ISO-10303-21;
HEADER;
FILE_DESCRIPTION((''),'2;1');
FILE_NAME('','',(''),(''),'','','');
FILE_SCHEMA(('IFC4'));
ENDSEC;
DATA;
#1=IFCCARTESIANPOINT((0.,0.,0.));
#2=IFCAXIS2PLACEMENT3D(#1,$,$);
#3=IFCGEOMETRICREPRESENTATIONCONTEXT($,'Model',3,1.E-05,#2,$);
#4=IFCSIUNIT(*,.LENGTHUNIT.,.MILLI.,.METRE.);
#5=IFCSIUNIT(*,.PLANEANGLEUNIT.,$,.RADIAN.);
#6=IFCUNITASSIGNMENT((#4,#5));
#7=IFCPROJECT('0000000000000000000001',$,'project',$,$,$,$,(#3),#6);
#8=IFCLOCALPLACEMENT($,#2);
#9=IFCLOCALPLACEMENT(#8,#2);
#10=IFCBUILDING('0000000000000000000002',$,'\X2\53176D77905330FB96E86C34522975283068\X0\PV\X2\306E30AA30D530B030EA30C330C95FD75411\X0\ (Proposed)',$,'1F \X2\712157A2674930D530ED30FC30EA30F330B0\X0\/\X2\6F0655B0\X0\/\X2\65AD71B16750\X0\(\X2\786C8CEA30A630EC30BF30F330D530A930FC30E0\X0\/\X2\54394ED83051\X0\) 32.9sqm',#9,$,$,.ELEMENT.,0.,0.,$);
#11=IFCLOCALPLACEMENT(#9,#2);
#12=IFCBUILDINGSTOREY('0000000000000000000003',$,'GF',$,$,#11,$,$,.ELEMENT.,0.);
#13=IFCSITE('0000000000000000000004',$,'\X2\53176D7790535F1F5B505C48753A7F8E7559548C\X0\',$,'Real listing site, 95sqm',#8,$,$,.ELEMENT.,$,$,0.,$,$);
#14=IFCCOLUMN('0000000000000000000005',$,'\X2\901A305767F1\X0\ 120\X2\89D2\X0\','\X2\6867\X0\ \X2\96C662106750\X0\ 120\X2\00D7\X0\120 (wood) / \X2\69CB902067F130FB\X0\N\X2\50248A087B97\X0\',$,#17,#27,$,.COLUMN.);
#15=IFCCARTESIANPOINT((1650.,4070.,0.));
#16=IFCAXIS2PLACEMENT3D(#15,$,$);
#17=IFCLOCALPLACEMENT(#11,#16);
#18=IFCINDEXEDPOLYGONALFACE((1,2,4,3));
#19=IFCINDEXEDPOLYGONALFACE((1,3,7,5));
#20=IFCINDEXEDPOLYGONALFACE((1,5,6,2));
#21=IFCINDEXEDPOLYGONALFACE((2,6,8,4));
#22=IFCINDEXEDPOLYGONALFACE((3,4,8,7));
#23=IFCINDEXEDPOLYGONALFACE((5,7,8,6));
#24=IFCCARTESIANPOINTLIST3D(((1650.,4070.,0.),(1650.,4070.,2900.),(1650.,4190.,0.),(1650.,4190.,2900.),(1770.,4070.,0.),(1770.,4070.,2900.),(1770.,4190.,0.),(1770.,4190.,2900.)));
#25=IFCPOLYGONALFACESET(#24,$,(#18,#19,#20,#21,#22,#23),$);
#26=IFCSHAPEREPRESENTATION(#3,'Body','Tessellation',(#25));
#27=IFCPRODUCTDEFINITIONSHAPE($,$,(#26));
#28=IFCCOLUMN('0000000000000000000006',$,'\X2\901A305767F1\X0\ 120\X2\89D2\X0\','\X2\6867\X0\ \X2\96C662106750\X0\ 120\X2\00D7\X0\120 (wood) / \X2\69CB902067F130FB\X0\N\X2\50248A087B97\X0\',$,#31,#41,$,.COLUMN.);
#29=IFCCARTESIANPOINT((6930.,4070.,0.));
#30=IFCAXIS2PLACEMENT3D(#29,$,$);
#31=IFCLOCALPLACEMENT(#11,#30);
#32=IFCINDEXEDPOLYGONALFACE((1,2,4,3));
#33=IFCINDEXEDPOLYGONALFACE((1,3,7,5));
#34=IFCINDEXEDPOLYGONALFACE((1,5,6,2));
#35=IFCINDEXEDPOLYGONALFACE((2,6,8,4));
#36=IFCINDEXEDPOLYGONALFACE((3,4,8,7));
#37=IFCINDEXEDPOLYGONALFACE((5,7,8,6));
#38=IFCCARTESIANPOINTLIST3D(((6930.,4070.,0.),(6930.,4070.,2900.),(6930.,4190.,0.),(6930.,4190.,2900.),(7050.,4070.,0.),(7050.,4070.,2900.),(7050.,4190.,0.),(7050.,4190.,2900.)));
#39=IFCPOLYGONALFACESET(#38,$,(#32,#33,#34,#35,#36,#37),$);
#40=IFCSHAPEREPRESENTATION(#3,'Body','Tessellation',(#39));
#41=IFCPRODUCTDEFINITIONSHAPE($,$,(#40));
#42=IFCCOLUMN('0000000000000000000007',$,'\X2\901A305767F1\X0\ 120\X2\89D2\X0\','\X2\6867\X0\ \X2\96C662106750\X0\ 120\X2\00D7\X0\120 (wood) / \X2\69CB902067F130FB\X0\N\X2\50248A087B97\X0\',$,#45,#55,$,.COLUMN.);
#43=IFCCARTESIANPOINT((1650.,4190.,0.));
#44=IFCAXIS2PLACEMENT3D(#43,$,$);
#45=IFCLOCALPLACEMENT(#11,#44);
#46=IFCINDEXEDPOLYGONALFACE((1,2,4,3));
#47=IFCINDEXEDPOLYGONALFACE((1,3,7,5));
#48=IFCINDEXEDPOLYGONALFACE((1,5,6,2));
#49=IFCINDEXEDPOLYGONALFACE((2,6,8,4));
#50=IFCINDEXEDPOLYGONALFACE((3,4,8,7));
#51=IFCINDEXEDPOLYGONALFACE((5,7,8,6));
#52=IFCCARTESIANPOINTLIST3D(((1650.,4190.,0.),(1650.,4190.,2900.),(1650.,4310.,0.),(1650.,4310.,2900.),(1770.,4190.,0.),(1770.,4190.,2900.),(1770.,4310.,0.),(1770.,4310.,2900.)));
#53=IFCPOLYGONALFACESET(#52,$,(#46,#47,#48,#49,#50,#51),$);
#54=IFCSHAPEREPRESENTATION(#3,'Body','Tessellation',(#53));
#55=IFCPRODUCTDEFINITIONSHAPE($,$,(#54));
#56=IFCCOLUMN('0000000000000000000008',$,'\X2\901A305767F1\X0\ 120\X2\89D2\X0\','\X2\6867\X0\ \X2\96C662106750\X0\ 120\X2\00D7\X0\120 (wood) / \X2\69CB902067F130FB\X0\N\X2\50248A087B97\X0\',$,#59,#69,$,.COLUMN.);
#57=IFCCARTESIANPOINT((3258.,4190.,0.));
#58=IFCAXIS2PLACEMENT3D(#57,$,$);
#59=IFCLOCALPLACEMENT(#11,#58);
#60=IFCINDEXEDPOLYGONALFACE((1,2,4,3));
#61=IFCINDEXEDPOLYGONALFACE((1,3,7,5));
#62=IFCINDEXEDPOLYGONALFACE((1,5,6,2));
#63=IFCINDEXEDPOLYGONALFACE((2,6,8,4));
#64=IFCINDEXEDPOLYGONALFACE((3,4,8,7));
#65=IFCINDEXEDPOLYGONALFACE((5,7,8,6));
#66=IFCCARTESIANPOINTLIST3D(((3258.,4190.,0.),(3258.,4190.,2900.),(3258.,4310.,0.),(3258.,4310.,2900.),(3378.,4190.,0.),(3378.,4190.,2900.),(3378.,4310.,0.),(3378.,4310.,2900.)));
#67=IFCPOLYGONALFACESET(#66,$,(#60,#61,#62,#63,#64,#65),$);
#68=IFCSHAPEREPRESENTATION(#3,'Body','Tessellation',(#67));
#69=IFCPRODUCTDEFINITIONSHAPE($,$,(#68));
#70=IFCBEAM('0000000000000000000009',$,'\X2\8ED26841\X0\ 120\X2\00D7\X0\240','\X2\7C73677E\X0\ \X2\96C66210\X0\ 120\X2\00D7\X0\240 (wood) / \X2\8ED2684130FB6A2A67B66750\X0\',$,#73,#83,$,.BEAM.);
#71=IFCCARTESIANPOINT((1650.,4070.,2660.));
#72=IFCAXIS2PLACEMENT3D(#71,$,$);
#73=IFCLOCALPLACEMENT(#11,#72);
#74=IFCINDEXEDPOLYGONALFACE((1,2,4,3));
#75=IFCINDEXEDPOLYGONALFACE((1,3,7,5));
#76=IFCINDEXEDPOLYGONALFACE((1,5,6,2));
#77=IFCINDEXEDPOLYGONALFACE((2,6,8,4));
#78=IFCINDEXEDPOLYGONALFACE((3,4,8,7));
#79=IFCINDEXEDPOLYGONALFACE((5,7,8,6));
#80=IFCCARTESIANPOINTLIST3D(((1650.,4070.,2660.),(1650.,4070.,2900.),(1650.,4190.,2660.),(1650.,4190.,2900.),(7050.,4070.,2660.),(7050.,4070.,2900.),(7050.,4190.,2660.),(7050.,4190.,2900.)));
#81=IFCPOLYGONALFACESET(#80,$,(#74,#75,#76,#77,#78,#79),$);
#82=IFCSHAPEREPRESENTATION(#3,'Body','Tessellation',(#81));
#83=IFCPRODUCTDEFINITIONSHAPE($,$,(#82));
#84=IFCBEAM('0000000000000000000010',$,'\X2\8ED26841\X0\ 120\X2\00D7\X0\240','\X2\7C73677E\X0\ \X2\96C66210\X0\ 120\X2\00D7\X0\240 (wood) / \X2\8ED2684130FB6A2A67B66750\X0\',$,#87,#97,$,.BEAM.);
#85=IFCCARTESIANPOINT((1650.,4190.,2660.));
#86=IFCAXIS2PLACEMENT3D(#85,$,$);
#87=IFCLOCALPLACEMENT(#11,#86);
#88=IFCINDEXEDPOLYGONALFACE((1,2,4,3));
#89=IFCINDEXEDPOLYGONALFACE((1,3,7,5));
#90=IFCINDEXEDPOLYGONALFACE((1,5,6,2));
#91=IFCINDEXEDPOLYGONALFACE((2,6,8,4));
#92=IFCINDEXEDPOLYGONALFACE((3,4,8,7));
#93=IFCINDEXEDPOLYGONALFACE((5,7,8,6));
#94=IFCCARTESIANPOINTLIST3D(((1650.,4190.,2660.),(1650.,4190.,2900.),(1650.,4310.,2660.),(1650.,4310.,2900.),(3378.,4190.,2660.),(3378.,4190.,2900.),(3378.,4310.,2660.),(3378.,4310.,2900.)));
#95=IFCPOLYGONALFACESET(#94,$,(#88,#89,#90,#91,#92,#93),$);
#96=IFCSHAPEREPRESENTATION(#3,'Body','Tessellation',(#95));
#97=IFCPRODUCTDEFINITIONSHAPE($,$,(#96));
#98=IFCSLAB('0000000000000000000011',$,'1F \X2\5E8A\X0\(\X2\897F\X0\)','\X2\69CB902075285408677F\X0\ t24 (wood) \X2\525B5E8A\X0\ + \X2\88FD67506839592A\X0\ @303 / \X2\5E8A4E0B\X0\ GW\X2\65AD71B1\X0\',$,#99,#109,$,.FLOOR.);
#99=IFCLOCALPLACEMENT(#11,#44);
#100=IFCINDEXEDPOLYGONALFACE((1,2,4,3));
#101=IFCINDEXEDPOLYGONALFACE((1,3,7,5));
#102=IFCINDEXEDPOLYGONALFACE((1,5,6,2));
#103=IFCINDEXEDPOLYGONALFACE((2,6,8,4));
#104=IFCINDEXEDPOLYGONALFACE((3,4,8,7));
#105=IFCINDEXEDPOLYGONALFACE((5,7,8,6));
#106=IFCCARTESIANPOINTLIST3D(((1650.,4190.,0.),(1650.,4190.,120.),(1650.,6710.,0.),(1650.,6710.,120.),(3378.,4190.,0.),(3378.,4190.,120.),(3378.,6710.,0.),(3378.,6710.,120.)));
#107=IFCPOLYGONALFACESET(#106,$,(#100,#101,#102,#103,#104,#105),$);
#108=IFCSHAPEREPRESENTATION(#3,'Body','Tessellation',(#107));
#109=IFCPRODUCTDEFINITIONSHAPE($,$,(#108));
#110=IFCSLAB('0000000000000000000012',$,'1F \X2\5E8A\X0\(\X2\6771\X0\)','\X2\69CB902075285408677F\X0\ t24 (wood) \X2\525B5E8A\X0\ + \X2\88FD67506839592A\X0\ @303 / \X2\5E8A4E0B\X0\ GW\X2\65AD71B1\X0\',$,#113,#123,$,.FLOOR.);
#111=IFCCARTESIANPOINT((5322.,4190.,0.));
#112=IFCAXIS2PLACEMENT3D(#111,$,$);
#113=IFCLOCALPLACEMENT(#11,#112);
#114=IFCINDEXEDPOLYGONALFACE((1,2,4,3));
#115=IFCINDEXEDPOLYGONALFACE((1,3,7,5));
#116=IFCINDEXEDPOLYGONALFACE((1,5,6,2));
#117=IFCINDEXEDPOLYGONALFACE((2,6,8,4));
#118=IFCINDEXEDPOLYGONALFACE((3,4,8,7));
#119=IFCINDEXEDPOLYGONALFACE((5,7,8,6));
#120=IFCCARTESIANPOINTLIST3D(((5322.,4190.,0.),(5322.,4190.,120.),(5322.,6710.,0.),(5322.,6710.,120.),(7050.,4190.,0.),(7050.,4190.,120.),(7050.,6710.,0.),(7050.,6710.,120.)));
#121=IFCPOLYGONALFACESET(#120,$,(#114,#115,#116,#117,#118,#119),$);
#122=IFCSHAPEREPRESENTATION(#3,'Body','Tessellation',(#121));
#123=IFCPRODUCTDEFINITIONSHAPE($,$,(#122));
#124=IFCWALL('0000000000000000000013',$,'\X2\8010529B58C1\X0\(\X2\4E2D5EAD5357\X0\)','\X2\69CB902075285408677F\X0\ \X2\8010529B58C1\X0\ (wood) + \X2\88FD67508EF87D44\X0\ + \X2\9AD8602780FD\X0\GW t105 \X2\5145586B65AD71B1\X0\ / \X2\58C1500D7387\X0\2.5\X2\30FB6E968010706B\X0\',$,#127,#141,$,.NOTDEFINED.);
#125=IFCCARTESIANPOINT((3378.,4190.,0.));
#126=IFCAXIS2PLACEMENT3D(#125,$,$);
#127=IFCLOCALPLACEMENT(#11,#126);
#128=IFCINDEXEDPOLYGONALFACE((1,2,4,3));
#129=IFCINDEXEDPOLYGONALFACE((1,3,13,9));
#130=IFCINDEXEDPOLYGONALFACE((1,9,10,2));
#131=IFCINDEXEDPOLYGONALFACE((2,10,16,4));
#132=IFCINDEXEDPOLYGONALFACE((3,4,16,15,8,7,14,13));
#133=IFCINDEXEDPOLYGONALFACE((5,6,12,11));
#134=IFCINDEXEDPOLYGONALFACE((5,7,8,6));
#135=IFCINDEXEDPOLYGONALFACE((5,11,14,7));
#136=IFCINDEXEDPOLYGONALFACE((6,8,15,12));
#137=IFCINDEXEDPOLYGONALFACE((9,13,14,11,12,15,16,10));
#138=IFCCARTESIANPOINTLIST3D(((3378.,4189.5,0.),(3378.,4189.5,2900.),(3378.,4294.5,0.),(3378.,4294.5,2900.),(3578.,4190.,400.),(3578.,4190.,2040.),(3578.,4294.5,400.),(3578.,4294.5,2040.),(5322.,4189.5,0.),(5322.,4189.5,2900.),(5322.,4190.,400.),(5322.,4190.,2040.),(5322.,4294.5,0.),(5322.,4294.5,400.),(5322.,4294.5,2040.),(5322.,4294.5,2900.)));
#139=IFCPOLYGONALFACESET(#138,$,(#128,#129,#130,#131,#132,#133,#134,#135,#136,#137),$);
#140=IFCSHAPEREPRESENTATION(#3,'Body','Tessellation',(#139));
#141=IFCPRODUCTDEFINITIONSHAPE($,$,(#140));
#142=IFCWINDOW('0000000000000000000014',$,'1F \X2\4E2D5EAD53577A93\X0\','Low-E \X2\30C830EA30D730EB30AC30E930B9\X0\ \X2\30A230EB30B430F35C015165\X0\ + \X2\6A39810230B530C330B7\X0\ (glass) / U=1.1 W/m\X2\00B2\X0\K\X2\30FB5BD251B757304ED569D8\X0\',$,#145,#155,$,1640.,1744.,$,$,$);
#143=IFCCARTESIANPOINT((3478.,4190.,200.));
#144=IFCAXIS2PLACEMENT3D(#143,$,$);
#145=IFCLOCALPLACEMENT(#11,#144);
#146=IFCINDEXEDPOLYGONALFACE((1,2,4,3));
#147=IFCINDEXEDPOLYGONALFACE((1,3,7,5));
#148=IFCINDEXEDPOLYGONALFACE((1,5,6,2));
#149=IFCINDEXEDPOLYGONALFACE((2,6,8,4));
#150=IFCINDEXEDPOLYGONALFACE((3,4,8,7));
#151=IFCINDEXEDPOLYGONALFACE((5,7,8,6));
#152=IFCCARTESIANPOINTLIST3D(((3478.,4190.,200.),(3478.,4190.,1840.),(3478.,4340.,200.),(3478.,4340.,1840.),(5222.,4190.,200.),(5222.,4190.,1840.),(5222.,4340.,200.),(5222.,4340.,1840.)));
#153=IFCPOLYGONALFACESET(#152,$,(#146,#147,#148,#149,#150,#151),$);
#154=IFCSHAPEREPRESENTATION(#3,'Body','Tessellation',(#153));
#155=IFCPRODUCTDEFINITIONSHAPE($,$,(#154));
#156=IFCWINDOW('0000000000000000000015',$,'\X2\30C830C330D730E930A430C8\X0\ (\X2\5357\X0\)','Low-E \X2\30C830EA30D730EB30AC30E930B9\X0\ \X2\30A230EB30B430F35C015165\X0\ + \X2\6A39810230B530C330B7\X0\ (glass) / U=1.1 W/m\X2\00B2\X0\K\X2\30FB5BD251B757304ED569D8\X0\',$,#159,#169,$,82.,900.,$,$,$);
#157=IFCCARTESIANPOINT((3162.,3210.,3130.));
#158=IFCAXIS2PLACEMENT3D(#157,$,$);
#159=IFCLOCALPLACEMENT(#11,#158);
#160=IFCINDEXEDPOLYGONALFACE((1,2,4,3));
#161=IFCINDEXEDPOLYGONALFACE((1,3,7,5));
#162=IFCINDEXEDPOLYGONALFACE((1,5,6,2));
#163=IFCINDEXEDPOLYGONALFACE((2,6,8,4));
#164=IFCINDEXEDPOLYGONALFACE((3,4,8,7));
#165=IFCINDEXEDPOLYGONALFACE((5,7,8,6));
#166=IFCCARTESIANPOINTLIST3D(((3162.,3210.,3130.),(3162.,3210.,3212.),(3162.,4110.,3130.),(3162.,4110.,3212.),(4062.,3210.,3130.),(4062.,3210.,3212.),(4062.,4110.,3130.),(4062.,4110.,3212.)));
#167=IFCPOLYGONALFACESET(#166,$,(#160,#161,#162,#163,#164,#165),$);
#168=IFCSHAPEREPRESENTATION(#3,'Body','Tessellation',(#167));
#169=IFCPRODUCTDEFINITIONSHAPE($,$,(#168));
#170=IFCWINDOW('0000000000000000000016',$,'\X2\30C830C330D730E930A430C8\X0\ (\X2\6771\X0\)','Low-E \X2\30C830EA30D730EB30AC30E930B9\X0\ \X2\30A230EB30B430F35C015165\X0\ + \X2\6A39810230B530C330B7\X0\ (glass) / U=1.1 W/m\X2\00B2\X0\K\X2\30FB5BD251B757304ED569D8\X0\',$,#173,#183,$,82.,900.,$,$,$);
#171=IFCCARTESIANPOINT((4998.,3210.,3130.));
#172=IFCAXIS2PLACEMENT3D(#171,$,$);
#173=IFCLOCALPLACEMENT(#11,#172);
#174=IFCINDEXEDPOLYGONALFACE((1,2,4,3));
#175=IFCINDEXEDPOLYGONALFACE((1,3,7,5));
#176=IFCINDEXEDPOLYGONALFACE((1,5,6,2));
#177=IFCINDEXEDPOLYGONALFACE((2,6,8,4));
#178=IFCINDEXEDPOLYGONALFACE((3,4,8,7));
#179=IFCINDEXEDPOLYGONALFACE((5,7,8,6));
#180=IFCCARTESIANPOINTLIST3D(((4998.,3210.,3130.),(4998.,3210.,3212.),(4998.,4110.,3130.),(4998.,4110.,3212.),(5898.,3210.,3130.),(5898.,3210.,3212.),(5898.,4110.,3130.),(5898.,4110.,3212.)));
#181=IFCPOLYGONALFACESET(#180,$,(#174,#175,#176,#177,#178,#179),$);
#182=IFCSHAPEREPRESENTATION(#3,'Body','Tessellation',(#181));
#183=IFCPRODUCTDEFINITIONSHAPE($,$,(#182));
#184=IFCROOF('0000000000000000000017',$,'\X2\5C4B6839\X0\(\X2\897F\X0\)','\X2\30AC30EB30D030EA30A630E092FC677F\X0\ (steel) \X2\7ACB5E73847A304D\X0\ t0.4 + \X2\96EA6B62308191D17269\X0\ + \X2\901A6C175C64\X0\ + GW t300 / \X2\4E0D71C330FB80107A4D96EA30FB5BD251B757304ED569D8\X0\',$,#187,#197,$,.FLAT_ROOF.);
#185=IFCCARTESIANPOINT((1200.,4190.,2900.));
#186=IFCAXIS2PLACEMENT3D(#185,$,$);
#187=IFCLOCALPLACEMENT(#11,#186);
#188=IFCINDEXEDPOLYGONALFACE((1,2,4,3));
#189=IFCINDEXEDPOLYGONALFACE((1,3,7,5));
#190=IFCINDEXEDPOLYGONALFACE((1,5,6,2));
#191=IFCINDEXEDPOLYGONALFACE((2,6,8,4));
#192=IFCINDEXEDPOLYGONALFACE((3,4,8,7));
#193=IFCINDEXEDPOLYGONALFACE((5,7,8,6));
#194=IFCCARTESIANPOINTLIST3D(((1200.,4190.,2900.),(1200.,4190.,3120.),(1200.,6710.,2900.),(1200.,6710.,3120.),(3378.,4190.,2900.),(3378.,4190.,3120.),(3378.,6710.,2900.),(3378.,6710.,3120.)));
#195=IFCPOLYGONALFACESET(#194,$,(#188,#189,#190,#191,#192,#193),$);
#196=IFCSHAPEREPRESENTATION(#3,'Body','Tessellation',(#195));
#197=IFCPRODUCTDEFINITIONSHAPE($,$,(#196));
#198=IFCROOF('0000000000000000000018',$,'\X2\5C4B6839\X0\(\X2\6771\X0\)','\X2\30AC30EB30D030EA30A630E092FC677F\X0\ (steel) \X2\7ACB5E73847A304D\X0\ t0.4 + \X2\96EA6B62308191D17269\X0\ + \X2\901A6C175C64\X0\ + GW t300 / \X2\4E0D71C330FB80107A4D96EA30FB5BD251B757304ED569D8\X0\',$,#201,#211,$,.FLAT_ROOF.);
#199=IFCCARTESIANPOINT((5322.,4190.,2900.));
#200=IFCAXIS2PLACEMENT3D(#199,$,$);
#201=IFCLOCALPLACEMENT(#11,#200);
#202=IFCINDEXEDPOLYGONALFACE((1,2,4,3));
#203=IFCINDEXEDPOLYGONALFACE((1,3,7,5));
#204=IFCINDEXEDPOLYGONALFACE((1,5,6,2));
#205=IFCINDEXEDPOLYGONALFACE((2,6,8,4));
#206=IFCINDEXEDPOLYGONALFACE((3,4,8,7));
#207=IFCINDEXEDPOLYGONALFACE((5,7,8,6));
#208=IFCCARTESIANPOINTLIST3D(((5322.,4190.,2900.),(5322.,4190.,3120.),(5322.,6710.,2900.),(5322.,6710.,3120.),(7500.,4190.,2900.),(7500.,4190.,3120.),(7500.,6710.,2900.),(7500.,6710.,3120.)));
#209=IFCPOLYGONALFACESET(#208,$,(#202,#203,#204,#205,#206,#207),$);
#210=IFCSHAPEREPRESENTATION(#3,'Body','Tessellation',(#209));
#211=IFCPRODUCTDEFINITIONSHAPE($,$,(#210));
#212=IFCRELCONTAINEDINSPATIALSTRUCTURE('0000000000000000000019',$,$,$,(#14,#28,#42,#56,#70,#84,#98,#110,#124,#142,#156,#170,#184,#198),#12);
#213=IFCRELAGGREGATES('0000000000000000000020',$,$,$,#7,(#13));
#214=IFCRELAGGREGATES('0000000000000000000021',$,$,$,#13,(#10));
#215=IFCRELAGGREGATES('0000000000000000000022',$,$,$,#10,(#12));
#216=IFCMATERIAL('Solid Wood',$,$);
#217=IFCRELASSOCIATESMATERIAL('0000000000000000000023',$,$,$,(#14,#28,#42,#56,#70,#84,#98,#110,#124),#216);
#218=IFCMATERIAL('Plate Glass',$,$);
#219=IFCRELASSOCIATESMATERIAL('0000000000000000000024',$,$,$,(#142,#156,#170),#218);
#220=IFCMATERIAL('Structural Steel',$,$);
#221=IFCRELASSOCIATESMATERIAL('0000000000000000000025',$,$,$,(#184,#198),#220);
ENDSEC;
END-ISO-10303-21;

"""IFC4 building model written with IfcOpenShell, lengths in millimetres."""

from ifc_helpers import new_model, si_unit, frame, frame_2d, origin, place, context, project, spatial, rectangle, extrude, material, element, fill, save


model = new_model("IFC4")

# Units and contexts
model_context = context("Model", 3, precision=1e-05, world=origin())
ifc_project = project(units=[si_unit("LENGTHUNIT", "METRE", prefix="MILLI"), si_unit("PLANEANGLEUNIT", "RADIAN")], contexts=[model_context])

# Site, building, storey
site_placement = place(None, origin())
site = spatial("IfcSite", under=ifc_project, at=site_placement, Name="北海道弟子屈町美留和", ObjectType="Real listing site, 95sqm", CompositionType="ELEMENT", RefElevation=0.0)
building_placement = place(site_placement, origin())
building = spatial("IfcBuilding", under=site, at=building_placement, Name="北海道・雨水利用とPVのオフグリッド志向 (Proposed)", ObjectType="1F 無垢杉フローリング/漆喰/断熱材(硬質ウレタンフォーム/吹付け) 32.9sqm", CompositionType="ELEMENT", ElevationOfRefHeight=0.0, ElevationOfTerrain=0.0)
storey_placement = place(building_placement, origin())
storey = spatial("IfcBuildingStorey", under=building, at=storey_placement, Name="GF", CompositionType="ELEMENT", Elevation=0.0)

# Columns
ifc_material_1 = material(Name="Solid Wood")
column_1_placement = place(storey_placement, frame((1650.0, 4070.0, 0.0)))
element("IfcColumn", 1, at=column_1_placement, inside=storey, material=ifc_material_1, Name="通し柱 120角", Description="桧 集成材 120×120 (wood) / 構造柱・N値計算", PredefinedType="COLUMN", context=model_context, shape_type="SweptSolid", body=[
    extrude(rectangle(XDim=120.0, YDim=120.0, at=frame_2d((60.0, 60.0))), frame((1650.0, 4070.0, 0.0)), (0.0, 0.0, 1.0), 2900.0),
])
column_2_placement = place(storey_placement, frame((6930.0, 4070.0, 0.0)))
element("IfcColumn", 2, at=column_2_placement, inside=storey, material=ifc_material_1, Name="通し柱 120角", Description="桧 集成材 120×120 (wood) / 構造柱・N値計算", PredefinedType="COLUMN", context=model_context, shape_type="SweptSolid", body=[
    extrude(rectangle(XDim=120.0, YDim=120.0, at=frame_2d((60.0, 60.0))), frame((6930.0, 4070.0, 0.0)), (0.0, 0.0, 1.0), 2900.0),
])
column_3_placement = place(storey_placement, frame((1650.0, 4190.0, 0.0)))
element("IfcColumn", 3, at=column_3_placement, inside=storey, material=ifc_material_1, Name="通し柱 120角", Description="桧 集成材 120×120 (wood) / 構造柱・N値計算", PredefinedType="COLUMN", context=model_context, shape_type="SweptSolid", body=[
    extrude(rectangle(XDim=120.0, YDim=120.0, at=frame_2d((60.0, 60.0))), frame((1650.0, 4190.0, 0.0)), (0.0, 0.0, 1.0), 2900.0),
])
column_4_placement = place(storey_placement, frame((3258.0, 4190.0, 0.0)))
element("IfcColumn", 4, at=column_4_placement, inside=storey, material=ifc_material_1, Name="通し柱 120角", Description="桧 集成材 120×120 (wood) / 構造柱・N値計算", PredefinedType="COLUMN", context=model_context, shape_type="SweptSolid", body=[
    extrude(rectangle(XDim=120.0, YDim=120.0, at=frame_2d((60.0, 60.0))), frame((3258.0, 4190.0, 0.0)), (0.0, 0.0, 1.0), 2900.0),
])

# Beams
beam_1_placement = place(storey_placement, frame((1650.0, 4070.0, 2660.0)))
element("IfcBeam", 5, at=beam_1_placement, inside=storey, material=ifc_material_1, Name="軒桁 120×240", Description="米松 集成 120×240 (wood) / 軒桁・横架材", PredefinedType="BEAM", context=model_context, shape_type="SweptSolid", body=[
    extrude(rectangle(XDim=5400.0, YDim=120.0, at=frame_2d((2700.0, 60.0))), frame((1650.0, 4070.0, 2660.0)), (0.0, 0.0, 1.0), 240.0),
])
beam_2_placement = place(storey_placement, frame((1650.0, 4190.0, 2660.0)))
element("IfcBeam", 6, at=beam_2_placement, inside=storey, material=ifc_material_1, Name="軒桁 120×240", Description="米松 集成 120×240 (wood) / 軒桁・横架材", PredefinedType="BEAM", context=model_context, shape_type="SweptSolid", body=[
    extrude(rectangle(XDim=1728.0, YDim=120.0, at=frame_2d((864.0, 60.0))), frame((1650.0, 4190.0, 2660.0)), (0.0, 0.0, 1.0), 240.0),
])

# Slabs
slab_1_placement = place(storey_placement, frame((1650.0, 4190.0, 0.0)))
element("IfcSlab", 7, at=slab_1_placement, inside=storey, material=ifc_material_1, Name="1F 床(西)", Description="構造用合板 t24 (wood) 剛床 + 製材根太 @303 / 床下 GW断熱", PredefinedType="FLOOR", context=model_context, shape_type="SweptSolid", body=[
    extrude(rectangle(XDim=1728.0, YDim=2520.0, at=frame_2d((864.0, 1260.0))), frame((1650.0, 4190.0, 0.0)), (0.0, 0.0, 1.0), 120.0),
])
slab_2_placement = place(storey_placement, frame((5322.0, 4190.0, 0.0)))
element("IfcSlab", 8, at=slab_2_placement, inside=storey, material=ifc_material_1, Name="1F 床(東)", Description="構造用合板 t24 (wood) 剛床 + 製材根太 @303 / 床下 GW断熱", PredefinedType="FLOOR", context=model_context, shape_type="SweptSolid", body=[
    extrude(rectangle(XDim=1728.0, YDim=2520.0, at=frame_2d((864.0, 1260.0))), frame((5322.0, 4190.0, 0.0)), (0.0, 0.0, 1.0), 120.0),
])

# Wall, opening, window
wall_1_placement = place(storey_placement, frame((3378.0, 4190.0, 0.0)))
wall_1 = element("IfcWall", 9, at=wall_1_placement, inside=storey, material=ifc_material_1, Name="耐力壁(中庭南)", Description="構造用合板 耐力壁 (wood) + 製材軸組 + 高性能GW t105 充填断熱 / 壁倍率2.5・準耐火", PredefinedType="NOTDEFINED", context=model_context, shape_type="SweptSolid", body=[
    extrude(rectangle(XDim=1944.0, YDim=105.0, at=frame_2d((972.0, 52.0))), frame((3378.0, 4190.0, 0.0)), (0.0, 0.0, 1.0), 2900.0),
])
opening_placement = place(storey_placement, frame((3478.0, 4190.0, 200.0)))
opening = element("IfcOpeningElement", 10, at=opening_placement, cuts=wall_1, PredefinedType="NOTDEFINED", context=model_context, shape_type="SweptSolid", body=[
    extrude(rectangle(XDim=1744.0, YDim=150.0, at=frame_2d((872.0, 75.0))), frame((3478.0, 4190.0, 200.0)), (0.0, 0.0, 1.0), 1640.0),
])
ifc_material_2 = material(Name="Plate Glass")
window_1_placement = place(storey_placement, frame((3478.0, 4190.0, 200.0)))
window_1 = element("IfcWindow", 11, at=window_1_placement, inside=storey, material=ifc_material_2, Name="1F 中庭南窓", Description="Low-E トリプルガラス アルゴン封入 + 樹脂サッシ (glass) / U=1.1 W/m²K・寒冷地仕様", OverallHeight=1640.0, OverallWidth=1744.0, context=model_context, shape_type="SweptSolid", body=[
    extrude(rectangle(XDim=1744.0, YDim=150.0, at=frame_2d((872.0, 75.0))), frame((3478.0, 4190.0, 200.0)), (0.0, 0.0, 1.0), 1640.0),
])
fill(opening, window_1)

# Windows
window_2_placement = place(storey_placement, frame((3162.0, 3210.0, 3130.0)))
element("IfcWindow", 12, at=window_2_placement, inside=storey, material=ifc_material_2, Name="トップライト (南)", Description="Low-E トリプルガラス アルゴン封入 + 樹脂サッシ (glass) / U=1.1 W/m²K・寒冷地仕様", OverallHeight=82.0, OverallWidth=900.0, context=model_context, shape_type="SweptSolid", body=[
    extrude(rectangle(XDim=900.0, YDim=900.0, at=frame_2d((450.0, 450.0))), frame((3162.0, 3210.0, 3130.0)), (0.0, 0.0, 1.0), 82.0),
])
window_3_placement = place(storey_placement, frame((4998.0, 3210.0, 3130.0)))
element("IfcWindow", 13, at=window_3_placement, inside=storey, material=ifc_material_2, Name="トップライト (東)", Description="Low-E トリプルガラス アルゴン封入 + 樹脂サッシ (glass) / U=1.1 W/m²K・寒冷地仕様", OverallHeight=82.0, OverallWidth=900.0, context=model_context, shape_type="SweptSolid", body=[
    extrude(rectangle(XDim=900.0, YDim=900.0, at=frame_2d((450.0, 450.0))), frame((4998.0, 3210.0, 3130.0)), (0.0, 0.0, 1.0), 82.0),
])

# Roofs
ifc_material_3 = material(Name="Structural Steel")
roof_1_placement = place(storey_placement, frame((1200.0, 4190.0, 2900.0)))
element("IfcRoof", 14, at=roof_1_placement, inside=storey, material=ifc_material_3, Name="屋根(西)", Description="ガルバリウム鋼板 (steel) 立平葺き t0.4 + 雪止め金物 + 通気層 + GW t300 / 不燃・耐積雪・寒冷地仕様", PredefinedType="FLAT_ROOF", context=model_context, shape_type="SweptSolid", body=[
    extrude(rectangle(XDim=2178.0, YDim=2520.0, at=frame_2d((1089.0, 1260.0))), frame((1200.0, 4190.0, 2900.0)), (0.0, 0.0, 1.0), 220.0),
])
roof_2_placement = place(storey_placement, frame((5322.0, 4190.0, 2900.0)))
element("IfcRoof", 15, at=roof_2_placement, inside=storey, material=ifc_material_3, Name="屋根(東)", Description="ガルバリウム鋼板 (steel) 立平葺き t0.4 + 雪止め金物 + 通気層 + GW t300 / 不燃・耐積雪・寒冷地仕様", PredefinedType="FLAT_ROOF", context=model_context, shape_type="SweptSolid", body=[
    extrude(rectangle(XDim=2178.0, YDim=2520.0, at=frame_2d((1089.0, 1260.0))), frame((5322.0, 4190.0, 2900.0)), (0.0, 0.0, 1.0), 220.0),
])

save(model, "model.ifc")
